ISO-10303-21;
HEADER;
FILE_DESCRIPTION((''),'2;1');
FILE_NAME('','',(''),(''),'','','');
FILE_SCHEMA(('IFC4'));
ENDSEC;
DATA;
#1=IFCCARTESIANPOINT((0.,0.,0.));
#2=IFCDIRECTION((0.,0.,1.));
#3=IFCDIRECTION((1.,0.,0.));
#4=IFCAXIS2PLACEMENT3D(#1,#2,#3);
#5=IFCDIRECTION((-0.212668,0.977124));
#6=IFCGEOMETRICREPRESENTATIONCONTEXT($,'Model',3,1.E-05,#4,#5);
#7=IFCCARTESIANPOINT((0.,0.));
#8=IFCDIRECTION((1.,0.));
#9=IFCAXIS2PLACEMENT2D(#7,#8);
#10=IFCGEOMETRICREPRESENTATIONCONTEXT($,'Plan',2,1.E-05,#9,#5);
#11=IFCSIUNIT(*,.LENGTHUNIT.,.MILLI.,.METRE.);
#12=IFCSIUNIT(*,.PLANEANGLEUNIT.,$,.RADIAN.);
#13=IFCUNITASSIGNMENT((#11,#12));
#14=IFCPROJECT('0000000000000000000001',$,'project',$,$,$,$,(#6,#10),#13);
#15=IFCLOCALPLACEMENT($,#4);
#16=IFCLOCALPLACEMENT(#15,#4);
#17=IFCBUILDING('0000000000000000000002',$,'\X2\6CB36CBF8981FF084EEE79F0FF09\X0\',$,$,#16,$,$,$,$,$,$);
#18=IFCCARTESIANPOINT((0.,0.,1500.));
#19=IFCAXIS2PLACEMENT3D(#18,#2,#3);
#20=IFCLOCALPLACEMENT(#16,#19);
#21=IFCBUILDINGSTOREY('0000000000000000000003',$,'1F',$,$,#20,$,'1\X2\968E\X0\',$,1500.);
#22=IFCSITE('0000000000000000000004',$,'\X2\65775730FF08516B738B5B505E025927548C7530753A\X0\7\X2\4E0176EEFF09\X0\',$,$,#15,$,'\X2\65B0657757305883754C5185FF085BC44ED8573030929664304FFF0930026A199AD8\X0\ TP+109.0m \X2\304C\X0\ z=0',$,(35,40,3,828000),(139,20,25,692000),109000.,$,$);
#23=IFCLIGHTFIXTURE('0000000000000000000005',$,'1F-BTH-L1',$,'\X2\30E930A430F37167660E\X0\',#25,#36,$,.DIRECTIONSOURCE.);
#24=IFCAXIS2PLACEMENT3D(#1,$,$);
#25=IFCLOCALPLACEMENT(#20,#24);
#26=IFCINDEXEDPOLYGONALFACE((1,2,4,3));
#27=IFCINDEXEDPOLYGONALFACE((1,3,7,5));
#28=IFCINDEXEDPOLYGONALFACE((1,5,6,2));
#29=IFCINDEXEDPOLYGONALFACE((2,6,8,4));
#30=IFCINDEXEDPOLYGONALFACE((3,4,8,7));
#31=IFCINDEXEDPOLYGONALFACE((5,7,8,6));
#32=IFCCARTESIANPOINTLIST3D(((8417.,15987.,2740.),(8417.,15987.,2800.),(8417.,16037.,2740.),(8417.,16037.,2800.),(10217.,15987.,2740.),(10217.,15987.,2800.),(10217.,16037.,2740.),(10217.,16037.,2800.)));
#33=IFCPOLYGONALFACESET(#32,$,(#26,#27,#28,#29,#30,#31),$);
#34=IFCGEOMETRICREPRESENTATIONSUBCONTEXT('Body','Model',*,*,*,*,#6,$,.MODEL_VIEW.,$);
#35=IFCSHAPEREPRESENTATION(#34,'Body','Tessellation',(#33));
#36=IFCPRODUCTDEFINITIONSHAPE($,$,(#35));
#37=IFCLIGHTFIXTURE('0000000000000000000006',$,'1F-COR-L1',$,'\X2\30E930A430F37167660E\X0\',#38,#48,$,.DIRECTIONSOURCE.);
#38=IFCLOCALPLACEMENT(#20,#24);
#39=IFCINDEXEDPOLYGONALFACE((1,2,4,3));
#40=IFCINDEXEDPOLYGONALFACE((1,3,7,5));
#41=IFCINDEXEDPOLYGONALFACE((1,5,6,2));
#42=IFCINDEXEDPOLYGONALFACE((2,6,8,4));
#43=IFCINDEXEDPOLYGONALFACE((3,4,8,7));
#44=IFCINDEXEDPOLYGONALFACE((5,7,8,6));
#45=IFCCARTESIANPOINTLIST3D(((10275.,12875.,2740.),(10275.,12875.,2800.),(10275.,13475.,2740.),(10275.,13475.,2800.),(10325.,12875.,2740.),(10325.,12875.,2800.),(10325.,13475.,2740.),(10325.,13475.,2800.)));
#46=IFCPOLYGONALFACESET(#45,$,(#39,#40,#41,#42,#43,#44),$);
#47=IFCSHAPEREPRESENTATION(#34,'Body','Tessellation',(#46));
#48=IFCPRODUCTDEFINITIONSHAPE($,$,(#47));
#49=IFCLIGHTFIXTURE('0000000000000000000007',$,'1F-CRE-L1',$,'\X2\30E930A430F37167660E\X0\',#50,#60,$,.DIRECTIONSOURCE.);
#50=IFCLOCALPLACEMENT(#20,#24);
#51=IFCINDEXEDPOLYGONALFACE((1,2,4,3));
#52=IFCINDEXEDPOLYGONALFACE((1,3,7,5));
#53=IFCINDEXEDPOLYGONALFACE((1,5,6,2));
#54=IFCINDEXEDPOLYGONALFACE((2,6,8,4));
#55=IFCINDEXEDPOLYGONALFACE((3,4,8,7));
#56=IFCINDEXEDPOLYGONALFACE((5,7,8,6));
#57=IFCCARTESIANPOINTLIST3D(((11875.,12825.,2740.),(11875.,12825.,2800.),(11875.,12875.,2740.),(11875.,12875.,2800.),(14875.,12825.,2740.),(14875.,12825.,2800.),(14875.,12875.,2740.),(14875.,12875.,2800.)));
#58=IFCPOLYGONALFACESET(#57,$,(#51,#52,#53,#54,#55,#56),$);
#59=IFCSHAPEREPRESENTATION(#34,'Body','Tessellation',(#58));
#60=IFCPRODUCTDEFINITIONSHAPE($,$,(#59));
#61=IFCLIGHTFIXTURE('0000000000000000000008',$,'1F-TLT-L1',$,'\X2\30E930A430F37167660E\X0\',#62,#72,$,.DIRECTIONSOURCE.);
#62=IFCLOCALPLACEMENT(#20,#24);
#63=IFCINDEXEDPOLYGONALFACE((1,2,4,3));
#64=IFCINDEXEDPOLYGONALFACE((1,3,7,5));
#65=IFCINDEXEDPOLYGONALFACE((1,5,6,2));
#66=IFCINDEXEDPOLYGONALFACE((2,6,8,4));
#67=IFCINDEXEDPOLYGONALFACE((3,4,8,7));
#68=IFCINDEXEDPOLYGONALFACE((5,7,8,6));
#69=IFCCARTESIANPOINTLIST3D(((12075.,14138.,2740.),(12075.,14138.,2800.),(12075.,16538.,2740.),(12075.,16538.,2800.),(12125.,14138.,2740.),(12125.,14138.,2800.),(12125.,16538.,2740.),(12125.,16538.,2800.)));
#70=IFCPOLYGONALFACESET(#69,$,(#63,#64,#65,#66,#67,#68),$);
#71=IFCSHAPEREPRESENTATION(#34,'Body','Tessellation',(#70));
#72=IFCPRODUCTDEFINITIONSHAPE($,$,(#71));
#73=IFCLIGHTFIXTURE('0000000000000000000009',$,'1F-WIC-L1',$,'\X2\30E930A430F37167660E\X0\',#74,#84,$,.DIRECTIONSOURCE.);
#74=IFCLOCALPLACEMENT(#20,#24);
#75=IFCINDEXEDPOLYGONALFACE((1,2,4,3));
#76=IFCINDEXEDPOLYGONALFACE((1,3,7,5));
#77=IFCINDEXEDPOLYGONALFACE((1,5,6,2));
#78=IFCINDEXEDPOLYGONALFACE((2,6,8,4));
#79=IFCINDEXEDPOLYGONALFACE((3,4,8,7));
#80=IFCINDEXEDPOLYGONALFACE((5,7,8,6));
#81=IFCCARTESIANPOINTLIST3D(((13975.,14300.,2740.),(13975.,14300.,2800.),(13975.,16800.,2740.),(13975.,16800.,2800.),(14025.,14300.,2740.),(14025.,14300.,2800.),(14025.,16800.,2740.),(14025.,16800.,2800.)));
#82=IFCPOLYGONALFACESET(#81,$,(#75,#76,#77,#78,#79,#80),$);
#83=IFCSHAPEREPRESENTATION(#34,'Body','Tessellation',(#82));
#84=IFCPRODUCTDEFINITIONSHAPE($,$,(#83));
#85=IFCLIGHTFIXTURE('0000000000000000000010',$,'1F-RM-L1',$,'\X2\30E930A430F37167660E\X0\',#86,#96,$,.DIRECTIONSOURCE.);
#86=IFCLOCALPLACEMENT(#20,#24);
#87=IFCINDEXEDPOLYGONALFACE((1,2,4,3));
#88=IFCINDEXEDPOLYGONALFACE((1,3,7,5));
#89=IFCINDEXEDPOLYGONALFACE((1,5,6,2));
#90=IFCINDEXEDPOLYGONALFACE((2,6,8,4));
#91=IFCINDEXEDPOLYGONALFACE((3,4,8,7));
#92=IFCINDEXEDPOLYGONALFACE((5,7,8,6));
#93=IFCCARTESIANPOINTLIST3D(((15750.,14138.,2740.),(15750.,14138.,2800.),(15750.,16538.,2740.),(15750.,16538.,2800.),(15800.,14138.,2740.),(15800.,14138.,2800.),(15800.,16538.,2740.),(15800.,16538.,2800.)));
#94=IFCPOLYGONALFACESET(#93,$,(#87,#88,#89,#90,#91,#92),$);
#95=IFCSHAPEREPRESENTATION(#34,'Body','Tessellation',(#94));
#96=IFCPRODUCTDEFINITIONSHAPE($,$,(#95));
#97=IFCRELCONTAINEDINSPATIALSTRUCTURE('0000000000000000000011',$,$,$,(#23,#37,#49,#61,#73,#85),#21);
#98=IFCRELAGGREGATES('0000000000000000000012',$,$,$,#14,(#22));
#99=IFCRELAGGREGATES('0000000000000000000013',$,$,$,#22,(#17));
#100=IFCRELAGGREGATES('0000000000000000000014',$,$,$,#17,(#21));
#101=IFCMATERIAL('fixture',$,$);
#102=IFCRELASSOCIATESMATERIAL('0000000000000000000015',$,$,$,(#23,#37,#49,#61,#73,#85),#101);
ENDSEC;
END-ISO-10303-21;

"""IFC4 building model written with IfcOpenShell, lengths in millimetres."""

from ifc_helpers import new_model, si_unit, direction, frame, frame_2d, origin_with_axes, origin_2d_with_axis, place, context, subcontext, project, spatial, rectangle, extrude, material, element, save


model = new_model("IFC4")

# Units and contexts
model_context = context("Model", 3, precision=1e-05, world=origin_with_axes(), true_north=direction((-0.212668, 0.977124)))
plan_context = context("Plan", 2, precision=1e-05, world=origin_2d_with_axis(), true_north=direction((-0.212668, 0.977124)))
body_context = subcontext(model_context, "Body", "Model", "MODEL_VIEW")
ifc_project = project(units=[si_unit("LENGTHUNIT", "METRE", prefix="MILLI"), si_unit("PLANEANGLEUNIT", "RADIAN")], contexts=[model_context, plan_context])

# Site, building, storey
site_placement = place(None, origin_with_axes())
site = spatial("IfcSite", under=ifc_project, at=site_placement, Name="敷地（八王子市大和田町7丁目）", LongName="新敷地境界内（寄付地を除く）。標高 TP+109.0m が z=0", RefLatitude=(35, 40, 3, 828000), RefLongitude=(139, 20, 25, 692000), RefElevation=109000.0)
building_placement = place(site_placement, origin_with_axes())
building = spatial("IfcBuilding", under=site, at=building_placement, Name="河沿要（仮称）")
storey_placement = place(building_placement, frame((0.0, 0.0, 1500.0), z_axis=(0.0, 0.0, 1.0), x_axis=(1.0, 0.0, 0.0)))
storey = spatial("IfcBuildingStorey", under=building, at=storey_placement, Name="1F", LongName="1階", Elevation=1500.0)

# Light fixtures
ifc_material = material(Name="fixture")
light_fixture_1_placement = place(storey_placement, origin_with_axes())
element("IfcLightFixture", 1, at=light_fixture_1_placement, inside=storey, material=ifc_material, Name="1F-BTH-L1", ObjectType="ライン照明", PredefinedType="DIRECTIONSOURCE", context=body_context, shape_type="SweptSolid", body=[
    extrude(rectangle(XDim=1800.0, YDim=50.0, at=frame_2d((9317.0, 16012.0))), frame((0.0, 0.0, 2740.0)), (0.0, 0.0, 1.0), 60.0),
])
light_fixture_2_placement = place(storey_placement, origin_with_axes())
element("IfcLightFixture", 2, at=light_fixture_2_placement, inside=storey, material=ifc_material, Name="1F-COR-L1", ObjectType="ライン照明", PredefinedType="DIRECTIONSOURCE", context=body_context, shape_type="SweptSolid", body=[
    extrude(rectangle(XDim=50.0, YDim=600.0, at=frame_2d((10300.0, 13175.0))), frame((0.0, 0.0, 2740.0)), (0.0, 0.0, 1.0), 60.0),
])
light_fixture_3_placement = place(storey_placement, origin_with_axes())
element("IfcLightFixture", 3, at=light_fixture_3_placement, inside=storey, material=ifc_material, Name="1F-CRE-L1", ObjectType="ライン照明", PredefinedType="DIRECTIONSOURCE", context=body_context, shape_type="SweptSolid", body=[
    extrude(rectangle(XDim=3000.0, YDim=50.0, at=frame_2d((13375.0, 12850.0))), frame((0.0, 0.0, 2740.0)), (0.0, 0.0, 1.0), 60.0),
])
light_fixture_4_placement = place(storey_placement, origin_with_axes())
element("IfcLightFixture", 4, at=light_fixture_4_placement, inside=storey, material=ifc_material, Name="1F-TLT-L1", ObjectType="ライン照明", PredefinedType="DIRECTIONSOURCE", context=body_context, shape_type="SweptSolid", body=[
    extrude(rectangle(XDim=50.0, YDim=2400.0, at=frame_2d((12100.0, 15338.0))), frame((0.0, 0.0, 2740.0)), (0.0, 0.0, 1.0), 60.0),
])
light_fixture_5_placement = place(storey_placement, origin_with_axes())
element("IfcLightFixture", 5, at=light_fixture_5_placement, inside=storey, material=ifc_material, Name="1F-WIC-L1", ObjectType="ライン照明", PredefinedType="DIRECTIONSOURCE", context=body_context, shape_type="SweptSolid", body=[
    extrude(rectangle(XDim=50.0, YDim=2500.0, at=frame_2d((14000.0, 15550.0))), frame((0.0, 0.0, 2740.0)), (0.0, 0.0, 1.0), 60.0),
])
light_fixture_6_placement = place(storey_placement, origin_with_axes())
element("IfcLightFixture", 6, at=light_fixture_6_placement, inside=storey, material=ifc_material, Name="1F-RM-L1", ObjectType="ライン照明", PredefinedType="DIRECTIONSOURCE", context=body_context, shape_type="SweptSolid", body=[
    extrude(rectangle(XDim=50.0, YDim=2400.0, at=frame_2d((15775.0, 15338.0))), frame((0.0, 0.0, 2740.0)), (0.0, 0.0, 1.0), 60.0),
])

save(model, "model.ifc")
